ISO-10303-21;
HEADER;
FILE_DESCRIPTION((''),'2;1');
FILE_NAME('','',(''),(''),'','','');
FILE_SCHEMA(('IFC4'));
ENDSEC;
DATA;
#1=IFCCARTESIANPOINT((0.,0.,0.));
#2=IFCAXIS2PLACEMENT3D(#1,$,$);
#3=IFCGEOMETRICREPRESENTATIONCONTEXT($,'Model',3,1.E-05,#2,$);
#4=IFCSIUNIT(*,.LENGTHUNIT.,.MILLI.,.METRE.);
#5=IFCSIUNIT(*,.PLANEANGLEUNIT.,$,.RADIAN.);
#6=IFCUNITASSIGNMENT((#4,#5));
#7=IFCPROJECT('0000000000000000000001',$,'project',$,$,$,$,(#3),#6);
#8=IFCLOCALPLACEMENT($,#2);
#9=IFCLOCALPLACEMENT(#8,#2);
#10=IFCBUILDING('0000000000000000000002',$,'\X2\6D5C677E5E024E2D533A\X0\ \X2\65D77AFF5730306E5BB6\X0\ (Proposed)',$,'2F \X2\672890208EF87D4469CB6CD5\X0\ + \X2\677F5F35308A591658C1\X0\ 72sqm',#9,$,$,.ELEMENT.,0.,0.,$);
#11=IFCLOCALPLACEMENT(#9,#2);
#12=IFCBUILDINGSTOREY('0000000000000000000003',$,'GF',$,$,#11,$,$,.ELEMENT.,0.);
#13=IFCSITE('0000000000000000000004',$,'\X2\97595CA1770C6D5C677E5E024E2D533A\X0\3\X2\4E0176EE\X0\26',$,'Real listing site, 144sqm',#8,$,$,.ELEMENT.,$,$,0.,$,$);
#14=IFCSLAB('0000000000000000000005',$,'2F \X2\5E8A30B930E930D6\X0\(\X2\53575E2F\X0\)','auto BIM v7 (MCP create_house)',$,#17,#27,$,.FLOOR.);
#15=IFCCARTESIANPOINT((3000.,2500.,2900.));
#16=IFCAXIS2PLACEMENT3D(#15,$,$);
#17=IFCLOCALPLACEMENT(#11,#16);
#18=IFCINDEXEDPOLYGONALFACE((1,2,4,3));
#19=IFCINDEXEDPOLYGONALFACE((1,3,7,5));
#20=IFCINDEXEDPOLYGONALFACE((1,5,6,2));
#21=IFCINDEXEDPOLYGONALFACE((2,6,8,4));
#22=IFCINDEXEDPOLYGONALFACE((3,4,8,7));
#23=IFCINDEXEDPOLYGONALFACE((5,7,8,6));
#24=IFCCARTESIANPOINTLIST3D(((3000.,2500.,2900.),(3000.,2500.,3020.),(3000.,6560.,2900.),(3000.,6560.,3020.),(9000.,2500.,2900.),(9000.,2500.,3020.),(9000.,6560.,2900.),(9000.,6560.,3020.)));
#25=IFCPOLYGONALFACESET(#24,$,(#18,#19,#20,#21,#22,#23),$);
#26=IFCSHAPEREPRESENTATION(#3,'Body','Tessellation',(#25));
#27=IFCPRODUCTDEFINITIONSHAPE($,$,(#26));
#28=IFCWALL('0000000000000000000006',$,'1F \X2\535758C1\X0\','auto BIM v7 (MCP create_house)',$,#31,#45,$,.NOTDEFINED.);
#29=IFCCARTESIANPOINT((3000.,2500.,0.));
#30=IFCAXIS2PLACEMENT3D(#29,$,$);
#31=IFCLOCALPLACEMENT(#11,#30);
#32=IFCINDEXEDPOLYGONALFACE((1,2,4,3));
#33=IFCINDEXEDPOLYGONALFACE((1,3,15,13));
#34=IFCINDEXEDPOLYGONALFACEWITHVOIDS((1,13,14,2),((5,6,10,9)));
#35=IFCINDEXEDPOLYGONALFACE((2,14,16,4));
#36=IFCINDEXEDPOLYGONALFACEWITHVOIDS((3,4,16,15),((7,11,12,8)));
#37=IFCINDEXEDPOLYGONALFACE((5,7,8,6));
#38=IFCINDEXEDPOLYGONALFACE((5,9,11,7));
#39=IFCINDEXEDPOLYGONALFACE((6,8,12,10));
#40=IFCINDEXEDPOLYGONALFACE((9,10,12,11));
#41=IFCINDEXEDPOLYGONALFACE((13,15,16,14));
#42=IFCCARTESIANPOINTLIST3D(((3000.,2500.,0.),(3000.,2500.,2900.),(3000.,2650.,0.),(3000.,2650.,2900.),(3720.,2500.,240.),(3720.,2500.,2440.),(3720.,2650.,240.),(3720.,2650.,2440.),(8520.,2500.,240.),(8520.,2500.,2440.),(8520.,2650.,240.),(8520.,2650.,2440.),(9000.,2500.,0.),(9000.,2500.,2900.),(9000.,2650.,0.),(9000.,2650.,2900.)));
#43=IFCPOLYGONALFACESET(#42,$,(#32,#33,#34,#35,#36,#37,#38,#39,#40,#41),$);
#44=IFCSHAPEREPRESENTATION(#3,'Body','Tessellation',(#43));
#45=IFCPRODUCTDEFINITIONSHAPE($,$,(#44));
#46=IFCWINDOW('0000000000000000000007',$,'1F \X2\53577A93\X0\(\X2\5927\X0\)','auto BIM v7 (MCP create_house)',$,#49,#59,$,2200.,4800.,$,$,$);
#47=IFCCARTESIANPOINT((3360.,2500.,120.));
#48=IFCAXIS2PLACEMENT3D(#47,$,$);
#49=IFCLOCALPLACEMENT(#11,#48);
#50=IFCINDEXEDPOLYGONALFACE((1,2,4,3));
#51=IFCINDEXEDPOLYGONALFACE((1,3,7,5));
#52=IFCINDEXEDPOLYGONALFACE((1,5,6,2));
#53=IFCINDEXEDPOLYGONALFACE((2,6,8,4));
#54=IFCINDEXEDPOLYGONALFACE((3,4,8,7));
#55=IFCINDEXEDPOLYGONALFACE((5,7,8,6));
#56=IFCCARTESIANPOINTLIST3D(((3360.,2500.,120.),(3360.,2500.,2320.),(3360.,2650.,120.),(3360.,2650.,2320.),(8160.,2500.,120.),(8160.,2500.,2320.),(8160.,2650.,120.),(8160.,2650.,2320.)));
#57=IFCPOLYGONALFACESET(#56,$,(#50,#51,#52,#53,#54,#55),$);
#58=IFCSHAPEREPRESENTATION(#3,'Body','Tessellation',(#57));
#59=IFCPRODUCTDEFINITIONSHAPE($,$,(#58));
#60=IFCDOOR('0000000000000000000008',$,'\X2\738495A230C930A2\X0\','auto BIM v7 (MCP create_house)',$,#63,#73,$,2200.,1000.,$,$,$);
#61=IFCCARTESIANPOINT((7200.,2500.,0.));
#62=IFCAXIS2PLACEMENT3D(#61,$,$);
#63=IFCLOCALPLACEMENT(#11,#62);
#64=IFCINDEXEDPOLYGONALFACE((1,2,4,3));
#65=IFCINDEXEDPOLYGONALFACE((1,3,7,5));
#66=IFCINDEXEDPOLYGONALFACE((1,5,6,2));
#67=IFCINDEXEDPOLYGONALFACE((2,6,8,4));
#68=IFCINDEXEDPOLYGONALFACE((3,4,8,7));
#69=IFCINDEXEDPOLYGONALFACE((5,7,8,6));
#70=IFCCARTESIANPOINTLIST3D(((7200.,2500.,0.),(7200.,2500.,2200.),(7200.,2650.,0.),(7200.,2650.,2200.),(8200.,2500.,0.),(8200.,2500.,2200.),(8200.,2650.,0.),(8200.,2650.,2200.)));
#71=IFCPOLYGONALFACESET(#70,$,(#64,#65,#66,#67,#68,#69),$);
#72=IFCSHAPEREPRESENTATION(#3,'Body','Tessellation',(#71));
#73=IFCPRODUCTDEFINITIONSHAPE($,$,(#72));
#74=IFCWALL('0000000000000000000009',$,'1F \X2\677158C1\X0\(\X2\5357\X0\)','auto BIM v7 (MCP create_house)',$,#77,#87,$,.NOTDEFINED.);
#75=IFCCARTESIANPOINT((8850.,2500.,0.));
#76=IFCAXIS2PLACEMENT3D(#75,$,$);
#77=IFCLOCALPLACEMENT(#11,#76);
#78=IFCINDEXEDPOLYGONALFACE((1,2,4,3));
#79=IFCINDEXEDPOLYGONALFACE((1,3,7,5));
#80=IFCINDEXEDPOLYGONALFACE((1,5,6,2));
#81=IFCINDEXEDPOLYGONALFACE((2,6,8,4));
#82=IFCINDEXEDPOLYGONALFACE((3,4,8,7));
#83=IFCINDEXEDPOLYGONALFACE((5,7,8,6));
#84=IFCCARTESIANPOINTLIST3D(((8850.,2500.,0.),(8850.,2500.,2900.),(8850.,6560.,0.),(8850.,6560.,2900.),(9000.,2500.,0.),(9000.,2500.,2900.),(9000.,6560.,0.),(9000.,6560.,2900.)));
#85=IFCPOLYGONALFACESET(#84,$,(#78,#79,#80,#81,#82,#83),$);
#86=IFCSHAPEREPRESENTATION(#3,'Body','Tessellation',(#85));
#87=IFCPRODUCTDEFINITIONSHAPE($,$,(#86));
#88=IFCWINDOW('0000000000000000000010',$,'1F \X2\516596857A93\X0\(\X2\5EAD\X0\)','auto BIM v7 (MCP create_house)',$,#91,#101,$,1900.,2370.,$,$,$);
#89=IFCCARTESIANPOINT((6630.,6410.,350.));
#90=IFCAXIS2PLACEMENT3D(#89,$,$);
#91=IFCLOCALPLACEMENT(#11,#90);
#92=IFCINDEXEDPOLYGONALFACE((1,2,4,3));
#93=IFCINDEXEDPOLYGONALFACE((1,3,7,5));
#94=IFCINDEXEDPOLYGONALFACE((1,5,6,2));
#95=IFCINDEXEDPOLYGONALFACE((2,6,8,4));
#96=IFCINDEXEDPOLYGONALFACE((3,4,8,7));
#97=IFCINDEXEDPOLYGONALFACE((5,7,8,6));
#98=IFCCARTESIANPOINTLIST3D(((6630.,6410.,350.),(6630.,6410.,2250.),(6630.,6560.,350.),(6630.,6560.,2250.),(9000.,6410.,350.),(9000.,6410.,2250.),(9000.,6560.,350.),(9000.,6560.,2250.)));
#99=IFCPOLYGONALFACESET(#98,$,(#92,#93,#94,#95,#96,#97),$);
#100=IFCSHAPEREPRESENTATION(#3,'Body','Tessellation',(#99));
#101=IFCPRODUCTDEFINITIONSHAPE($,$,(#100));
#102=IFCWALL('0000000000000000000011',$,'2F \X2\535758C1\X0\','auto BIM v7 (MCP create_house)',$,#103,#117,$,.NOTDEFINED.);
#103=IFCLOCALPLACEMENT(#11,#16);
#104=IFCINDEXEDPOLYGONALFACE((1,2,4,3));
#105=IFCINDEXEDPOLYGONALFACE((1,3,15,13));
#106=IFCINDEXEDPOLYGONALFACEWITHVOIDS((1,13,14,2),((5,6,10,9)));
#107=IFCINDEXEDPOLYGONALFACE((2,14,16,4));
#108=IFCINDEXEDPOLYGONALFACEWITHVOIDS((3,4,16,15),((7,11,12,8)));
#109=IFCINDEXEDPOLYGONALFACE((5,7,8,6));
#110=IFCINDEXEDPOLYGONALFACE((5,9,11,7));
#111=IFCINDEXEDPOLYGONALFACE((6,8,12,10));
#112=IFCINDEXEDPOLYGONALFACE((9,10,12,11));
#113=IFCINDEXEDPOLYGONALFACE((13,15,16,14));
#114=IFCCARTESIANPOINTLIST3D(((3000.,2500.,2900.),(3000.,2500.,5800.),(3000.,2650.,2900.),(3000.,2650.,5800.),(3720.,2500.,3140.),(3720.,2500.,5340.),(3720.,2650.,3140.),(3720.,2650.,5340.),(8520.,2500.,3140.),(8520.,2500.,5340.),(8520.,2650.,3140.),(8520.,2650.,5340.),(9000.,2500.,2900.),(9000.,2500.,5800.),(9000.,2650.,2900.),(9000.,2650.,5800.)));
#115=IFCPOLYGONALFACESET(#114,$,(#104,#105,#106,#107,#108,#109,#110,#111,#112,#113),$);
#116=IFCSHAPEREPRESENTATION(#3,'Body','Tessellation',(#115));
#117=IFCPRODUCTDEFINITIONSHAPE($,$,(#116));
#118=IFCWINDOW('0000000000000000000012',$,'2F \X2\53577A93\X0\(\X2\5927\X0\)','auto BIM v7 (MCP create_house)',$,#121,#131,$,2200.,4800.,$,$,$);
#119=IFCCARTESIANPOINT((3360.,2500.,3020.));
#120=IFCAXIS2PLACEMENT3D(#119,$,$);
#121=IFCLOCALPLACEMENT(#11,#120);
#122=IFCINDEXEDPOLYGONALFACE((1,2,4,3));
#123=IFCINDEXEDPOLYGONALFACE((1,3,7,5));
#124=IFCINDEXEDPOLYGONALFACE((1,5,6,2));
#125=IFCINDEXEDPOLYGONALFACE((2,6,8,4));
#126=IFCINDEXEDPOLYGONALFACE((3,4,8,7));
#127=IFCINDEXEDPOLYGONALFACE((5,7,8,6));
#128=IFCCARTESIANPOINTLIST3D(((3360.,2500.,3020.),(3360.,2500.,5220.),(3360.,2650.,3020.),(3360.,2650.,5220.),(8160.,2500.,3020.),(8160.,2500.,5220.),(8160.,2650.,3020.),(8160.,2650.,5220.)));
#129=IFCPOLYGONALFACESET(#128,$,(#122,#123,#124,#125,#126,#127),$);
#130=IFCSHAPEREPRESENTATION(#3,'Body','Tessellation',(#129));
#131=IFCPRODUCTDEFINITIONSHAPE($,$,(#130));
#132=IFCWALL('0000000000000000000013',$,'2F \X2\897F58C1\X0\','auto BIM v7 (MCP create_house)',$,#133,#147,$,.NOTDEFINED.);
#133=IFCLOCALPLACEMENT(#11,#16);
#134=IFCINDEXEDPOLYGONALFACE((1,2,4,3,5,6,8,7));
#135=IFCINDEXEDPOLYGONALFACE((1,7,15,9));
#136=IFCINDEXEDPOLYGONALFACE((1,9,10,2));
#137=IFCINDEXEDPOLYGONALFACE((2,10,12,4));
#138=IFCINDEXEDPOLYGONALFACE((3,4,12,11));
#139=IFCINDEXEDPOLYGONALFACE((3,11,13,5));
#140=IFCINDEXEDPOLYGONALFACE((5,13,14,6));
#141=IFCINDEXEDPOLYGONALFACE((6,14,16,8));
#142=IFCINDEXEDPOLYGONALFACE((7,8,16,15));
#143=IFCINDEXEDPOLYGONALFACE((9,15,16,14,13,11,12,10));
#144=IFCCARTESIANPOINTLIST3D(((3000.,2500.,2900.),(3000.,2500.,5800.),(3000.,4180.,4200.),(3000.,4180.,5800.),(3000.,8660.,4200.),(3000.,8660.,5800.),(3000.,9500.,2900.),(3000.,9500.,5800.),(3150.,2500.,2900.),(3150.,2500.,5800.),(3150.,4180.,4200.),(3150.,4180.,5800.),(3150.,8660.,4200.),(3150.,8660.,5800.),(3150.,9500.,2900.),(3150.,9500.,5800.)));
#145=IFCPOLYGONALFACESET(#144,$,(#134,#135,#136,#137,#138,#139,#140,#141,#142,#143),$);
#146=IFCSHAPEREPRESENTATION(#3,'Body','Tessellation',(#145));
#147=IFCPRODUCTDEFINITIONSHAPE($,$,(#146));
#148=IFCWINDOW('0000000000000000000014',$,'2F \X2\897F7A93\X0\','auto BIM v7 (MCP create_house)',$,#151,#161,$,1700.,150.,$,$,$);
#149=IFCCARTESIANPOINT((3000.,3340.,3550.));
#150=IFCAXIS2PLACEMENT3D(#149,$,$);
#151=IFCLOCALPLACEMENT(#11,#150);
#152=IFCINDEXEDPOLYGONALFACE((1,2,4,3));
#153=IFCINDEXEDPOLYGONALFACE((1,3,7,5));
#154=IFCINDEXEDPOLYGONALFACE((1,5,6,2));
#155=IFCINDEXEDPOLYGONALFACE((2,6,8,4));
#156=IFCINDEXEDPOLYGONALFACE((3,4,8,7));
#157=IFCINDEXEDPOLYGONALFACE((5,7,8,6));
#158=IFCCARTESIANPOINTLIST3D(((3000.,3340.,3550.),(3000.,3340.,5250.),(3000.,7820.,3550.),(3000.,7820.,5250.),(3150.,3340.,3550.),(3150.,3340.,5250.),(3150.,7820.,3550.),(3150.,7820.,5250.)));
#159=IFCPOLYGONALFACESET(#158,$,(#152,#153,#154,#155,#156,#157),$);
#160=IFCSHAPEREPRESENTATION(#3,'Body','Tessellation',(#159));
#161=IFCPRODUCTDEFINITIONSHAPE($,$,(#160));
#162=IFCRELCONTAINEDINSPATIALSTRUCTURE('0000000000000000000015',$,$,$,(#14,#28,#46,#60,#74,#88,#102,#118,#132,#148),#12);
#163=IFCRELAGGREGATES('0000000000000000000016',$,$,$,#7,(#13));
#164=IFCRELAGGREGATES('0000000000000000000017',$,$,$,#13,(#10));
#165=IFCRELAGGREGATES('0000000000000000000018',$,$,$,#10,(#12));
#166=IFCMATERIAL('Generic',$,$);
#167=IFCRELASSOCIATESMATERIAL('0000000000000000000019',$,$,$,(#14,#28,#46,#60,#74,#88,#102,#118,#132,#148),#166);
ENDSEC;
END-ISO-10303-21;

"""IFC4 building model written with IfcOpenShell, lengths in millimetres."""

from ifc_helpers import new_model, si_unit, frame, frame_2d, origin, place, context, project, spatial, rectangle, extrude, material, element, fill, save


model = new_model("IFC4")

# Units and contexts
model_context = context("Model", 3, precision=1e-05, world=origin())
ifc_project = project(units=[si_unit("LENGTHUNIT", "METRE", prefix="MILLI"), si_unit("PLANEANGLEUNIT", "RADIAN")], contexts=[model_context])

# Site, building, storey
site_placement = place(None, origin())
site = spatial("IfcSite", under=ifc_project, at=site_placement, Name="静岡県浜松市中区3丁目26", ObjectType="Real listing site, 144sqm", CompositionType="ELEMENT", RefElevation=0.0)
building_placement = place(site_placement, origin())
building = spatial("IfcBuilding", under=site, at=building_placement, Name="浜松市中区 旗竿地の家 (Proposed)", ObjectType="2F 木造軸組構法 + 板張り外壁 72sqm", CompositionType="ELEMENT", ElevationOfRefHeight=0.0, ElevationOfTerrain=0.0)
storey_placement = place(building_placement, origin())
storey = spatial("IfcBuildingStorey", under=building, at=storey_placement, Name="GF", CompositionType="ELEMENT", Elevation=0.0)

# Slab
ifc_material = material(Name="Generic")
slab_1_placement = place(storey_placement, frame((3000.0, 2500.0, 2900.0)))
element("IfcSlab", 1, at=slab_1_placement, inside=storey, material=ifc_material, Name="2F 床スラブ(南帯)", Description="auto BIM v7 (MCP create_house)", PredefinedType="FLOOR", context=model_context, shape_type="SweptSolid", body=[
    extrude(rectangle(XDim=6000.0, YDim=4060.0, at=frame_2d((3000.0, 2030.0))), frame((3000.0, 2500.0, 2900.0)), (0.0, 0.0, 1.0), 120.0),
])

# Wall, openings, window, door
wall_1_placement = place(storey_placement, frame((3000.0, 2500.0, 0.0)))
wall_1 = element("IfcWall", 2, at=wall_1_placement, inside=storey, material=ifc_material, Name="1F 南壁", Description="auto BIM v7 (MCP create_house)", PredefinedType="NOTDEFINED", context=model_context, shape_type="SweptSolid", body=[
    extrude(rectangle(XDim=6000.0, YDim=150.0, at=frame_2d((3000.0, 75.0))), frame((3000.0, 2500.0, 0.0)), (0.0, 0.0, 1.0), 2900.0),
])
opening_1_placement = place(storey_placement, frame((3360.0, 2500.0, 120.0)))
opening_1 = element("IfcOpeningElement", 3, at=opening_1_placement, cuts=wall_1, PredefinedType="NOTDEFINED", context=model_context, shape_type="SweptSolid", body=[
    extrude(rectangle(XDim=4800.0, YDim=150.0, at=frame_2d((2400.0, 75.0))), frame((3360.0, 2500.0, 120.0)), (0.0, 0.0, 1.0), 2200.0),
])
opening_2_placement = place(storey_placement, frame((7200.0, 2500.0, 0.0)))
opening_2 = element("IfcOpeningElement", 4, at=opening_2_placement, cuts=wall_1, PredefinedType="NOTDEFINED", context=model_context, shape_type="SweptSolid", body=[
    extrude(rectangle(XDim=1000.0, YDim=150.0, at=frame_2d((500.0, 75.0))), frame((7200.0, 2500.0, 0.0)), (0.0, 0.0, 1.0), 2200.0),
])
window_1_placement = place(storey_placement, frame((3360.0, 2500.0, 120.0)))
window_1 = element("IfcWindow", 5, at=window_1_placement, inside=storey, material=ifc_material, Name="1F 南窓(大)", Description="auto BIM v7 (MCP create_house)", OverallHeight=2200.0, OverallWidth=4800.0, context=model_context, shape_type="SweptSolid", body=[
    extrude(rectangle(XDim=4800.0, YDim=150.0, at=frame_2d((2400.0, 75.0))), frame((3360.0, 2500.0, 120.0)), (0.0, 0.0, 1.0), 2200.0),
])
fill(opening_1, window_1)
door_placement = place(storey_placement, frame((7200.0, 2500.0, 0.0)))
door = element("IfcDoor", 6, at=door_placement, inside=storey, material=ifc_material, Name="玄関ドア", Description="auto BIM v7 (MCP create_house)", OverallHeight=2200.0, OverallWidth=1000.0, context=model_context, shape_type="SweptSolid", body=[
    extrude(rectangle(XDim=1000.0, YDim=150.0, at=frame_2d((500.0, 75.0))), frame((7200.0, 2500.0, 0.0)), (0.0, 0.0, 1.0), 2200.0),
])
fill(opening_2, door)

# Wall, opening, window
wall_2_placement = place(storey_placement, frame((8850.0, 2500.0, 0.0)))
wall_2 = element("IfcWall", 7, at=wall_2_placement, inside=storey, material=ifc_material, Name="1F 東壁(南)", Description="auto BIM v7 (MCP create_house)", PredefinedType="NOTDEFINED", context=model_context, shape_type="SweptSolid", body=[
    extrude(rectangle(XDim=150.0, YDim=4060.0, at=frame_2d((75.0, 2030.0))), frame((8850.0, 2500.0, 0.0)), (0.0, 0.0, 1.0), 2900.0),
])
opening_3_placement = place(storey_placement, frame((6630.0, 6410.0, 350.0)))
opening_3 = element("IfcOpeningElement", 8, at=opening_3_placement, cuts=wall_2, PredefinedType="NOTDEFINED", context=model_context, shape_type="SweptSolid", body=[
    extrude(rectangle(XDim=2370.0, YDim=150.0, at=frame_2d((1185.0, 75.0))), frame((6630.0, 6410.0, 350.0)), (0.0, 0.0, 1.0), 1900.0),
])
window_2_placement = place(storey_placement, frame((6630.0, 6410.0, 350.0)))
window_2 = element("IfcWindow", 9, at=window_2_placement, inside=storey, material=ifc_material, Name="1F 入隅窓(庭)", Description="auto BIM v7 (MCP create_house)", OverallHeight=1900.0, OverallWidth=2370.0, context=model_context, shape_type="SweptSolid", body=[
    extrude(rectangle(XDim=2370.0, YDim=150.0, at=frame_2d((1185.0, 75.0))), frame((6630.0, 6410.0, 350.0)), (0.0, 0.0, 1.0), 1900.0),
])
fill(opening_3, window_2)

# Walls, openings, windows
wall_3_placement = place(storey_placement, frame((3000.0, 2500.0, 2900.0)))
wall_3 = element("IfcWall", 10, at=wall_3_placement, inside=storey, material=ifc_material, Name="2F 南壁", Description="auto BIM v7 (MCP create_house)", PredefinedType="NOTDEFINED", context=model_context, shape_type="SweptSolid", body=[
    extrude(rectangle(XDim=6000.0, YDim=150.0, at=frame_2d((3000.0, 75.0))), frame((3000.0, 2500.0, 2900.0)), (0.0, 0.0, 1.0), 2900.0),
])
opening_4_placement = place(storey_placement, frame((3360.0, 2500.0, 3020.0)))
opening_4 = element("IfcOpeningElement", 11, at=opening_4_placement, cuts=wall_3, PredefinedType="NOTDEFINED", context=model_context, shape_type="SweptSolid", body=[
    extrude(rectangle(XDim=4800.0, YDim=150.0, at=frame_2d((2400.0, 75.0))), frame((3360.0, 2500.0, 3020.0)), (0.0, 0.0, 1.0), 2200.0),
])
window_3_placement = place(storey_placement, frame((3360.0, 2500.0, 3020.0)))
window_3 = element("IfcWindow", 12, at=window_3_placement, inside=storey, material=ifc_material, Name="2F 南窓(大)", Description="auto BIM v7 (MCP create_house)", OverallHeight=2200.0, OverallWidth=4800.0, context=model_context, shape_type="SweptSolid", body=[
    extrude(rectangle(XDim=4800.0, YDim=150.0, at=frame_2d((2400.0, 75.0))), frame((3360.0, 2500.0, 3020.0)), (0.0, 0.0, 1.0), 2200.0),
])
fill(opening_4, window_3)
wall_4_placement = place(storey_placement, frame((3000.0, 2500.0, 2900.0)))
wall_4 = element("IfcWall", 13, at=wall_4_placement, inside=storey, material=ifc_material, Name="2F 西壁", Description="auto BIM v7 (MCP create_house)", PredefinedType="NOTDEFINED", context=model_context, shape_type="SweptSolid", body=[
    extrude(rectangle(XDim=150.0, YDim=7000.0, at=frame_2d((75.0, 3500.0))), frame((3000.0, 2500.0, 2900.0)), (0.0, 0.0, 1.0), 2900.0),
])
opening_5_placement = place(storey_placement, frame((3000.0, 3340.0, 3550.0)))
opening_5 = element("IfcOpeningElement", 14, at=opening_5_placement, cuts=wall_4, PredefinedType="NOTDEFINED", context=model_context, shape_type="SweptSolid", body=[
    extrude(rectangle(XDim=150.0, YDim=4480.0, at=frame_2d((75.0, 2240.0))), frame((3000.0, 3340.0, 3550.0)), (0.0, 0.0, 1.0), 1700.0),
])
window_4_placement = place(storey_placement, frame((3000.0, 3340.0, 3550.0)))
window_4 = element("IfcWindow", 15, at=window_4_placement, inside=storey, material=ifc_material, Name="2F 西窓", Description="auto BIM v7 (MCP create_house)", OverallHeight=1700.0, OverallWidth=150.0, context=model_context, shape_type="SweptSolid", body=[
    extrude(rectangle(XDim=150.0, YDim=4480.0, at=frame_2d((75.0, 2240.0))), frame((3000.0, 3340.0, 3550.0)), (0.0, 0.0, 1.0), 1700.0),
])
fill(opening_5, window_4)

save(model, "model.ifc")
